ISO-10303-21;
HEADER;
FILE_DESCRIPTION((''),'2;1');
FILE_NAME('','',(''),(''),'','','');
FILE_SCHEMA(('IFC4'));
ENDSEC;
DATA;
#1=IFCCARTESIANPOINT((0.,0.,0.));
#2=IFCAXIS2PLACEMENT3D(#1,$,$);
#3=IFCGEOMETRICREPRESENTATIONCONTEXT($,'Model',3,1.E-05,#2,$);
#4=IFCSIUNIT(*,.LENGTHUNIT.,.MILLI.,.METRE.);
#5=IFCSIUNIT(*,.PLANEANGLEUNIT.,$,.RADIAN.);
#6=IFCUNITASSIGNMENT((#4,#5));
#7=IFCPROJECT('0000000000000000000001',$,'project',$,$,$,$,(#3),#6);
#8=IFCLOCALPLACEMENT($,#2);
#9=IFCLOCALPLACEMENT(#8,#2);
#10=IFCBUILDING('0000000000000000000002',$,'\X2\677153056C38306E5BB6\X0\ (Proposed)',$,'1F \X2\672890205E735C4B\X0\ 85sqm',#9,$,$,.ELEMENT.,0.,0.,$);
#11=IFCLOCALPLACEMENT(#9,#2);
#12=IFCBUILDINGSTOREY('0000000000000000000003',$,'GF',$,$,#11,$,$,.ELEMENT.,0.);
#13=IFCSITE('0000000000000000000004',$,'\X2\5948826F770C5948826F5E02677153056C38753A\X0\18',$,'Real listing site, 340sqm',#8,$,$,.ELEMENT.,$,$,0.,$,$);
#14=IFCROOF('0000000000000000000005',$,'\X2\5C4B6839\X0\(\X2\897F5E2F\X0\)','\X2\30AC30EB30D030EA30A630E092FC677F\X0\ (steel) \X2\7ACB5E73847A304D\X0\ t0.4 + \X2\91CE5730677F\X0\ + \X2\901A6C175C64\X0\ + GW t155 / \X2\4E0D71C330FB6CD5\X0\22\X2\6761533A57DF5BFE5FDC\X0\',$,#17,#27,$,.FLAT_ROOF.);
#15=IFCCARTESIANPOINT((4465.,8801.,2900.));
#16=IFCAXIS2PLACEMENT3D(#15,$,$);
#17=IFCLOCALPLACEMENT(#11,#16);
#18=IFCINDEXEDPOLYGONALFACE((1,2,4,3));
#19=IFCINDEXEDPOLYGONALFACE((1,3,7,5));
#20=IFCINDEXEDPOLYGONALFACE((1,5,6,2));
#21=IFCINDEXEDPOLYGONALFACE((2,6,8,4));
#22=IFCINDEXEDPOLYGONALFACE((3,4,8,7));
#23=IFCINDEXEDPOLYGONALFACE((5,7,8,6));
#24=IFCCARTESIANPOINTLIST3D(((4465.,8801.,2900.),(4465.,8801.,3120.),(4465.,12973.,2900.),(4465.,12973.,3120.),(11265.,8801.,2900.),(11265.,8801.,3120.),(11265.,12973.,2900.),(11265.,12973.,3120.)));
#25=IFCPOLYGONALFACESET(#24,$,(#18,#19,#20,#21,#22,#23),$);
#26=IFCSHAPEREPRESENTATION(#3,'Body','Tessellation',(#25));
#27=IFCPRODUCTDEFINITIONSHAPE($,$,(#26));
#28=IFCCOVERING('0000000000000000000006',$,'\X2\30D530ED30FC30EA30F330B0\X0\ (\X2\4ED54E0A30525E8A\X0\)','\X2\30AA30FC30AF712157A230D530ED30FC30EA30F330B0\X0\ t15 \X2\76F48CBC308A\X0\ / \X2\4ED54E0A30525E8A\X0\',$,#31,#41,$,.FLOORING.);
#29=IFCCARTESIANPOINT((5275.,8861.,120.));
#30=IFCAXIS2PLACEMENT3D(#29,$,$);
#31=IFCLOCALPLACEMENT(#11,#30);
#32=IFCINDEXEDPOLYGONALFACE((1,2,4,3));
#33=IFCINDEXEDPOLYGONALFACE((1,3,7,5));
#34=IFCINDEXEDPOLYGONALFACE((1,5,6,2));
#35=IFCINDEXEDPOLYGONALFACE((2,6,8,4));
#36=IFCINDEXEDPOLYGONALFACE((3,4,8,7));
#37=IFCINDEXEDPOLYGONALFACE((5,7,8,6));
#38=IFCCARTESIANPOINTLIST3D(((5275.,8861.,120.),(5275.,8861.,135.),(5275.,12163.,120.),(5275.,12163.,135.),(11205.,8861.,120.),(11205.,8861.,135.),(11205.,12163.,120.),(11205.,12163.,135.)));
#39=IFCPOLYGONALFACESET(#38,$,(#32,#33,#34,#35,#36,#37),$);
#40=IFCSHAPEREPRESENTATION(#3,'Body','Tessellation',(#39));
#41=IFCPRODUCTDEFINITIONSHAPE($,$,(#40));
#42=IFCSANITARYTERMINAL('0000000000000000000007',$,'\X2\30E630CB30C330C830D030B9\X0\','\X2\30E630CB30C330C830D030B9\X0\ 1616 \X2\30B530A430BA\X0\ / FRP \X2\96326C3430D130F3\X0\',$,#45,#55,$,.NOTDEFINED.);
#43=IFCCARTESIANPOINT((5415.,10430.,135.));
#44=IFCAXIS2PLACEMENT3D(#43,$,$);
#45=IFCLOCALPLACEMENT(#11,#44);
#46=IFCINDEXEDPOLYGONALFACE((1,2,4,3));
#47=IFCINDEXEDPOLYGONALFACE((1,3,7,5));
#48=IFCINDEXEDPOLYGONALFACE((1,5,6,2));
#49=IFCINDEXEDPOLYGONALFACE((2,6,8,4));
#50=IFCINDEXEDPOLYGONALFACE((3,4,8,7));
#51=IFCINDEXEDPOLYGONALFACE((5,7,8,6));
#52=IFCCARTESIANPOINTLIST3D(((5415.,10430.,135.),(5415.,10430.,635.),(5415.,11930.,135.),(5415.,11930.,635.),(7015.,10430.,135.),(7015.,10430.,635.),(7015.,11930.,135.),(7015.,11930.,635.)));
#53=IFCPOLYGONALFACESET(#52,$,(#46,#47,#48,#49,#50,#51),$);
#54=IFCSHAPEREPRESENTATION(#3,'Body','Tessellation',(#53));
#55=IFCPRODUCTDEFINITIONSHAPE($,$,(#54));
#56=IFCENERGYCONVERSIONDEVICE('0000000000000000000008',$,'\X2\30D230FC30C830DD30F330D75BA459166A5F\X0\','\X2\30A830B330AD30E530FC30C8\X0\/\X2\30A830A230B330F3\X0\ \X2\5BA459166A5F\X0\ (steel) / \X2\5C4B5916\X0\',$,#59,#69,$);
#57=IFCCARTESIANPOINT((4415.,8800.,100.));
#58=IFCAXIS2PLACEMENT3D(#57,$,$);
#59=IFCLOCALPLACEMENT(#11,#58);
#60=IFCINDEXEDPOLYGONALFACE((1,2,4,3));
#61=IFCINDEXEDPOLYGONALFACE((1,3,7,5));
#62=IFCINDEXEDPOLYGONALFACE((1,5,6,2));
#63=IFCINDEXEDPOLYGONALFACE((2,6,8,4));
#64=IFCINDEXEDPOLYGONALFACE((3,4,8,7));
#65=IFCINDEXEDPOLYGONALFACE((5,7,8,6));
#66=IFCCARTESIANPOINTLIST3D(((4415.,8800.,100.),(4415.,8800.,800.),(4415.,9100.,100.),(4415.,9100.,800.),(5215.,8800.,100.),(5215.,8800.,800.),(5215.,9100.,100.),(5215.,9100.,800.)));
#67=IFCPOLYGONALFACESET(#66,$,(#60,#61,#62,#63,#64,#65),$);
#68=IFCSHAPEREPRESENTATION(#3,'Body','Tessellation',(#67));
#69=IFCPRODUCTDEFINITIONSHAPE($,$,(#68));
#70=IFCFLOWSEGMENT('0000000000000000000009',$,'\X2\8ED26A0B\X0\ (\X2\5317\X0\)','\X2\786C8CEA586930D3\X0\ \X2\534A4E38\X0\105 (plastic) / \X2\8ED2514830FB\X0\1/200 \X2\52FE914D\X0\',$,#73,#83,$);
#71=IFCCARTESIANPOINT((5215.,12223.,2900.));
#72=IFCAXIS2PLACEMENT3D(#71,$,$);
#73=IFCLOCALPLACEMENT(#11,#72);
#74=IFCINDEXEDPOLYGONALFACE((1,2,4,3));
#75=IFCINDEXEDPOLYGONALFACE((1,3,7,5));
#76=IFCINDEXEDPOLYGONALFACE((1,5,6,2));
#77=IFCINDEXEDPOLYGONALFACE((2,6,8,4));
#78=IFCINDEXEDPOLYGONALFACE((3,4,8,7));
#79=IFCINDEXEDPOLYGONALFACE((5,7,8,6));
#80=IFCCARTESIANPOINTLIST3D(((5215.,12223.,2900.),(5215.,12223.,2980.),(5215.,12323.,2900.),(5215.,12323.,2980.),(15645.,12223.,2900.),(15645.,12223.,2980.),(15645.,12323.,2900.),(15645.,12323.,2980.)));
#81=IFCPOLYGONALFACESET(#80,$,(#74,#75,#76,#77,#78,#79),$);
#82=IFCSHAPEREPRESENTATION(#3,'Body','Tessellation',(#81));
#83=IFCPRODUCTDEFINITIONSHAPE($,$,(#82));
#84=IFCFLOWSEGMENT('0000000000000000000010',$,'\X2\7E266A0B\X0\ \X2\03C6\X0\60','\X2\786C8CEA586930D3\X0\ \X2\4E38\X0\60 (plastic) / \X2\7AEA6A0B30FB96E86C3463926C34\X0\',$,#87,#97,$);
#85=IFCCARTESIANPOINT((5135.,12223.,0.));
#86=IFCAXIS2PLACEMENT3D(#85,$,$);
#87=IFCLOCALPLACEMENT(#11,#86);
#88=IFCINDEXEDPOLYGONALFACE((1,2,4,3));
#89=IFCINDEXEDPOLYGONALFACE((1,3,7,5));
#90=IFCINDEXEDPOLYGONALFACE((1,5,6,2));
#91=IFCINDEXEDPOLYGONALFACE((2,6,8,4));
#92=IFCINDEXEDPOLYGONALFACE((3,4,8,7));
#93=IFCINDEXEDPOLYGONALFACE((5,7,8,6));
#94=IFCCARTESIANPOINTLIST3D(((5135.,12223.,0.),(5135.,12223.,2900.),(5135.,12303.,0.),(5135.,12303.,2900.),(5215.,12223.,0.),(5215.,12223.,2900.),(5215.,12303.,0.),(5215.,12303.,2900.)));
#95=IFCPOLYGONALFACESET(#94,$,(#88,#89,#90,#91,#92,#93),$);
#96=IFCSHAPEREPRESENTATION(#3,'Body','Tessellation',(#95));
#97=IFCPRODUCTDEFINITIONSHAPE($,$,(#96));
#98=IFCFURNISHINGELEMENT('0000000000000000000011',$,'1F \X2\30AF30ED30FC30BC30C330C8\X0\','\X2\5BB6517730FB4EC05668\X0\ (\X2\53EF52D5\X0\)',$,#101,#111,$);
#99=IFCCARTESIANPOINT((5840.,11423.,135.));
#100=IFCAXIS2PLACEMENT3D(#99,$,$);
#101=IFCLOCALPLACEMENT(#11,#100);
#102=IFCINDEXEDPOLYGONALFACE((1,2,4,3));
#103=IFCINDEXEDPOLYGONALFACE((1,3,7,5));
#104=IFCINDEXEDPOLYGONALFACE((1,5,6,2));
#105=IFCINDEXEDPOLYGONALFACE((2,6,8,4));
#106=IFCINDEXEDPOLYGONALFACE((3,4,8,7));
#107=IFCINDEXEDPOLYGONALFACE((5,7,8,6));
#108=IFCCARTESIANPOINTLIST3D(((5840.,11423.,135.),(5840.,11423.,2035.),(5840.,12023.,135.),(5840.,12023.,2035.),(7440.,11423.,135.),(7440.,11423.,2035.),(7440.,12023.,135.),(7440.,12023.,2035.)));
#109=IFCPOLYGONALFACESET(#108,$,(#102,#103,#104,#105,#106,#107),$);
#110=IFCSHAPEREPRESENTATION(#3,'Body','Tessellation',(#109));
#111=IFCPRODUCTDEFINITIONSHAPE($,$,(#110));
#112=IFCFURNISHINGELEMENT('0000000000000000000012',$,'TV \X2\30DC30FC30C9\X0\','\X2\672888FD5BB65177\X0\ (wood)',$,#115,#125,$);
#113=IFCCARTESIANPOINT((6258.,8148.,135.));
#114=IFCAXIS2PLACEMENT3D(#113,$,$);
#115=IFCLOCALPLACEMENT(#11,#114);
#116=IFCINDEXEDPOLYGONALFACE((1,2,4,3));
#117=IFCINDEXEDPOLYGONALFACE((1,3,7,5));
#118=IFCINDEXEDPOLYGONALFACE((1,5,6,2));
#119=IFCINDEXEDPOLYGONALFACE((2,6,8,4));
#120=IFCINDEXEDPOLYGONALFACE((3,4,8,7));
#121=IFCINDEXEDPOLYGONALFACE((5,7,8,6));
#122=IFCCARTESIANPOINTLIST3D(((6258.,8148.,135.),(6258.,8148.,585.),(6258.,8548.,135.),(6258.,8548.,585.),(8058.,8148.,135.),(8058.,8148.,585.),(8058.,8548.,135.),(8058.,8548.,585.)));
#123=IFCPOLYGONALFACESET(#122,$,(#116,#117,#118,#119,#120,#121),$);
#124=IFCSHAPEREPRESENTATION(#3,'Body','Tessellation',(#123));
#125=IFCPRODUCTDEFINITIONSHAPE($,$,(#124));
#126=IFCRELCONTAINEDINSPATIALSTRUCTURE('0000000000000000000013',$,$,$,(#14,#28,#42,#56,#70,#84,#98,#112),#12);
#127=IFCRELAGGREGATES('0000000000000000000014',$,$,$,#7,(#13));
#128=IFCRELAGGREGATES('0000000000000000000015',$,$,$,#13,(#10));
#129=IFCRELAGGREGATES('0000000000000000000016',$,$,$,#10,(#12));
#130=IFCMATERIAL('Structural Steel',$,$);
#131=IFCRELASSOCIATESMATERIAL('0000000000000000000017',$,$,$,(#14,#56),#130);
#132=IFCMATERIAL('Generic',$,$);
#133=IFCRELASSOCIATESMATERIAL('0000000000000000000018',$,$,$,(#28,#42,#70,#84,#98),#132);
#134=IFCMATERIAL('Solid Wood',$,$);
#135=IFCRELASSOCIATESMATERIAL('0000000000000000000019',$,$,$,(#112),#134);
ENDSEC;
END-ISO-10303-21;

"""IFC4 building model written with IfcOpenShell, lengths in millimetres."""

from ifc_helpers import new_model, si_unit, frame, frame_2d, origin, place, context, project, spatial, rectangle, extrude, material, element, save


model = new_model("IFC4")

# Units and contexts
model_context = context("Model", 3, precision=1e-05, world=origin())
ifc_project = project(units=[si_unit("LENGTHUNIT", "METRE", prefix="MILLI"), si_unit("PLANEANGLEUNIT", "RADIAN")], contexts=[model_context])

# Site, building, storey
site_placement = place(None, origin())
site = spatial("IfcSite", under=ifc_project, at=site_placement, Name="奈良県奈良市東包永町18", ObjectType="Real listing site, 340sqm", CompositionType="ELEMENT", RefElevation=0.0)
building_placement = place(site_placement, origin())
building = spatial("IfcBuilding", under=site, at=building_placement, Name="東包永の家 (Proposed)", ObjectType="1F 木造平屋 85sqm", CompositionType="ELEMENT", ElevationOfRefHeight=0.0, ElevationOfTerrain=0.0)
storey_placement = place(building_placement, origin())
storey = spatial("IfcBuildingStorey", under=building, at=storey_placement, Name="GF", CompositionType="ELEMENT", Elevation=0.0)

# Shared definitions
ifc_material_1 = material(Name="Solid Wood")

# Roof
ifc_material_2 = material(Name="Structural Steel")
roof_placement = place(storey_placement, frame((4465.0, 8801.0, 2900.0)))
element("IfcRoof", 1, at=roof_placement, inside=storey, material=ifc_material_2, Name="屋根(西帯)", Description="ガルバリウム鋼板 (steel) 立平葺き t0.4 + 野地板 + 通気層 + GW t155 / 不燃・法22条区域対応", PredefinedType="FLAT_ROOF", context=model_context, shape_type="SweptSolid", body=[
    extrude(rectangle(XDim=6800.0, YDim=4172.0, at=frame_2d((3400.0, 2086.0))), frame((4465.0, 8801.0, 2900.0)), (0.0, 0.0, 1.0), 220.0),
])

# Covering
ifc_material_3 = material(Name="Generic")
covering_placement = place(storey_placement, frame((5275.0, 8861.0, 120.0)))
element("IfcCovering", 2, at=covering_placement, inside=storey, material=ifc_material_3, Name="フローリング (仕上げ床)", Description="オーク無垢フローリング t15 直貼り / 仕上げ床", PredefinedType="FLOORING", context=model_context, shape_type="SweptSolid", body=[
    extrude(rectangle(XDim=5930.0, YDim=3302.0, at=frame_2d((2965.0, 1651.0))), frame((5275.0, 8861.0, 120.0)), (0.0, 0.0, 1.0), 15.0),
])

# Sanitary terminal
sanitary_terminal_placement = place(storey_placement, frame((5415.0, 10430.0, 135.0)))
element("IfcSanitaryTerminal", 3, at=sanitary_terminal_placement, inside=storey, material=ifc_material_3, Name="ユニットバス", Description="ユニットバス 1616 サイズ / FRP 防水パン", PredefinedType="NOTDEFINED", context=model_context, shape_type="SweptSolid", body=[
    extrude(rectangle(XDim=1600.0, YDim=1500.0, at=frame_2d((800.0, 750.0))), frame((5415.0, 10430.0, 135.0)), (0.0, 0.0, 1.0), 500.0),
])

# Energy conversion device
energy_conversion_device_placement = place(storey_placement, frame((4415.0, 8800.0, 100.0)))
element("IfcEnergyConversionDevice", 4, at=energy_conversion_device_placement, inside=storey, material=ifc_material_2, Name="ヒートポンプ室外機", Description="エコキュート/エアコン 室外機 (steel) / 屋外", context=model_context, shape_type="SweptSolid", body=[
    extrude(rectangle(XDim=800.0, YDim=300.0, at=frame_2d((400.0, 150.0))), frame((4415.0, 8800.0, 100.0)), (0.0, 0.0, 1.0), 700.0),
])

# Flow segments
flow_segment_1_placement = place(storey_placement, frame((5215.0, 12223.0, 2900.0)))
element("IfcFlowSegment", 5, at=flow_segment_1_placement, inside=storey, material=ifc_material_3, Name="軒樋 (北)", Description="硬質塩ビ 半丸105 (plastic) / 軒先・1/200 勾配", context=model_context, shape_type="SweptSolid", body=[
    extrude(rectangle(XDim=10430.0, YDim=100.0, at=frame_2d((5215.0, 50.0))), frame((5215.0, 12223.0, 2900.0)), (0.0, 0.0, 1.0), 80.0),
])
flow_segment_2_placement = place(storey_placement, frame((5135.0, 12223.0, 0.0)))
element("IfcFlowSegment", 6, at=flow_segment_2_placement, inside=storey, material=ifc_material_3, Name="縦樋 φ60", Description="硬質塩ビ 丸60 (plastic) / 竪樋・雨水排水", context=model_context, shape_type="SweptSolid", body=[
    extrude(rectangle(XDim=80.0, YDim=80.0, at=frame_2d((40.0, 40.0))), frame((5135.0, 12223.0, 0.0)), (0.0, 0.0, 1.0), 2900.0),
])

# Furnishing elements
furnishing_1_placement = place(storey_placement, frame((5840.0, 11423.0, 135.0)))
element("IfcFurnishingElement", 7, at=furnishing_1_placement, inside=storey, material=ifc_material_3, Name="1F クローゼット", Description="家具・什器 (可動)", context=model_context, shape_type="SweptSolid", body=[
    extrude(rectangle(XDim=1600.0, YDim=600.0, at=frame_2d((800.0, 300.0))), frame((5840.0, 11423.0, 135.0)), (0.0, 0.0, 1.0), 1900.0),
])
furnishing_2_placement = place(storey_placement, frame((6258.0, 8148.0, 135.0)))
element("IfcFurnishingElement", 8, at=furnishing_2_placement, inside=storey, material=ifc_material_1, Name="TV ボード", Description="木製家具 (wood)", context=model_context, shape_type="SweptSolid", body=[
    extrude(rectangle(XDim=1800.0, YDim=400.0, at=frame_2d((900.0, 200.0))), frame((6258.0, 8148.0, 135.0)), (0.0, 0.0, 1.0), 450.0),
])

save(model, "model.ifc")
